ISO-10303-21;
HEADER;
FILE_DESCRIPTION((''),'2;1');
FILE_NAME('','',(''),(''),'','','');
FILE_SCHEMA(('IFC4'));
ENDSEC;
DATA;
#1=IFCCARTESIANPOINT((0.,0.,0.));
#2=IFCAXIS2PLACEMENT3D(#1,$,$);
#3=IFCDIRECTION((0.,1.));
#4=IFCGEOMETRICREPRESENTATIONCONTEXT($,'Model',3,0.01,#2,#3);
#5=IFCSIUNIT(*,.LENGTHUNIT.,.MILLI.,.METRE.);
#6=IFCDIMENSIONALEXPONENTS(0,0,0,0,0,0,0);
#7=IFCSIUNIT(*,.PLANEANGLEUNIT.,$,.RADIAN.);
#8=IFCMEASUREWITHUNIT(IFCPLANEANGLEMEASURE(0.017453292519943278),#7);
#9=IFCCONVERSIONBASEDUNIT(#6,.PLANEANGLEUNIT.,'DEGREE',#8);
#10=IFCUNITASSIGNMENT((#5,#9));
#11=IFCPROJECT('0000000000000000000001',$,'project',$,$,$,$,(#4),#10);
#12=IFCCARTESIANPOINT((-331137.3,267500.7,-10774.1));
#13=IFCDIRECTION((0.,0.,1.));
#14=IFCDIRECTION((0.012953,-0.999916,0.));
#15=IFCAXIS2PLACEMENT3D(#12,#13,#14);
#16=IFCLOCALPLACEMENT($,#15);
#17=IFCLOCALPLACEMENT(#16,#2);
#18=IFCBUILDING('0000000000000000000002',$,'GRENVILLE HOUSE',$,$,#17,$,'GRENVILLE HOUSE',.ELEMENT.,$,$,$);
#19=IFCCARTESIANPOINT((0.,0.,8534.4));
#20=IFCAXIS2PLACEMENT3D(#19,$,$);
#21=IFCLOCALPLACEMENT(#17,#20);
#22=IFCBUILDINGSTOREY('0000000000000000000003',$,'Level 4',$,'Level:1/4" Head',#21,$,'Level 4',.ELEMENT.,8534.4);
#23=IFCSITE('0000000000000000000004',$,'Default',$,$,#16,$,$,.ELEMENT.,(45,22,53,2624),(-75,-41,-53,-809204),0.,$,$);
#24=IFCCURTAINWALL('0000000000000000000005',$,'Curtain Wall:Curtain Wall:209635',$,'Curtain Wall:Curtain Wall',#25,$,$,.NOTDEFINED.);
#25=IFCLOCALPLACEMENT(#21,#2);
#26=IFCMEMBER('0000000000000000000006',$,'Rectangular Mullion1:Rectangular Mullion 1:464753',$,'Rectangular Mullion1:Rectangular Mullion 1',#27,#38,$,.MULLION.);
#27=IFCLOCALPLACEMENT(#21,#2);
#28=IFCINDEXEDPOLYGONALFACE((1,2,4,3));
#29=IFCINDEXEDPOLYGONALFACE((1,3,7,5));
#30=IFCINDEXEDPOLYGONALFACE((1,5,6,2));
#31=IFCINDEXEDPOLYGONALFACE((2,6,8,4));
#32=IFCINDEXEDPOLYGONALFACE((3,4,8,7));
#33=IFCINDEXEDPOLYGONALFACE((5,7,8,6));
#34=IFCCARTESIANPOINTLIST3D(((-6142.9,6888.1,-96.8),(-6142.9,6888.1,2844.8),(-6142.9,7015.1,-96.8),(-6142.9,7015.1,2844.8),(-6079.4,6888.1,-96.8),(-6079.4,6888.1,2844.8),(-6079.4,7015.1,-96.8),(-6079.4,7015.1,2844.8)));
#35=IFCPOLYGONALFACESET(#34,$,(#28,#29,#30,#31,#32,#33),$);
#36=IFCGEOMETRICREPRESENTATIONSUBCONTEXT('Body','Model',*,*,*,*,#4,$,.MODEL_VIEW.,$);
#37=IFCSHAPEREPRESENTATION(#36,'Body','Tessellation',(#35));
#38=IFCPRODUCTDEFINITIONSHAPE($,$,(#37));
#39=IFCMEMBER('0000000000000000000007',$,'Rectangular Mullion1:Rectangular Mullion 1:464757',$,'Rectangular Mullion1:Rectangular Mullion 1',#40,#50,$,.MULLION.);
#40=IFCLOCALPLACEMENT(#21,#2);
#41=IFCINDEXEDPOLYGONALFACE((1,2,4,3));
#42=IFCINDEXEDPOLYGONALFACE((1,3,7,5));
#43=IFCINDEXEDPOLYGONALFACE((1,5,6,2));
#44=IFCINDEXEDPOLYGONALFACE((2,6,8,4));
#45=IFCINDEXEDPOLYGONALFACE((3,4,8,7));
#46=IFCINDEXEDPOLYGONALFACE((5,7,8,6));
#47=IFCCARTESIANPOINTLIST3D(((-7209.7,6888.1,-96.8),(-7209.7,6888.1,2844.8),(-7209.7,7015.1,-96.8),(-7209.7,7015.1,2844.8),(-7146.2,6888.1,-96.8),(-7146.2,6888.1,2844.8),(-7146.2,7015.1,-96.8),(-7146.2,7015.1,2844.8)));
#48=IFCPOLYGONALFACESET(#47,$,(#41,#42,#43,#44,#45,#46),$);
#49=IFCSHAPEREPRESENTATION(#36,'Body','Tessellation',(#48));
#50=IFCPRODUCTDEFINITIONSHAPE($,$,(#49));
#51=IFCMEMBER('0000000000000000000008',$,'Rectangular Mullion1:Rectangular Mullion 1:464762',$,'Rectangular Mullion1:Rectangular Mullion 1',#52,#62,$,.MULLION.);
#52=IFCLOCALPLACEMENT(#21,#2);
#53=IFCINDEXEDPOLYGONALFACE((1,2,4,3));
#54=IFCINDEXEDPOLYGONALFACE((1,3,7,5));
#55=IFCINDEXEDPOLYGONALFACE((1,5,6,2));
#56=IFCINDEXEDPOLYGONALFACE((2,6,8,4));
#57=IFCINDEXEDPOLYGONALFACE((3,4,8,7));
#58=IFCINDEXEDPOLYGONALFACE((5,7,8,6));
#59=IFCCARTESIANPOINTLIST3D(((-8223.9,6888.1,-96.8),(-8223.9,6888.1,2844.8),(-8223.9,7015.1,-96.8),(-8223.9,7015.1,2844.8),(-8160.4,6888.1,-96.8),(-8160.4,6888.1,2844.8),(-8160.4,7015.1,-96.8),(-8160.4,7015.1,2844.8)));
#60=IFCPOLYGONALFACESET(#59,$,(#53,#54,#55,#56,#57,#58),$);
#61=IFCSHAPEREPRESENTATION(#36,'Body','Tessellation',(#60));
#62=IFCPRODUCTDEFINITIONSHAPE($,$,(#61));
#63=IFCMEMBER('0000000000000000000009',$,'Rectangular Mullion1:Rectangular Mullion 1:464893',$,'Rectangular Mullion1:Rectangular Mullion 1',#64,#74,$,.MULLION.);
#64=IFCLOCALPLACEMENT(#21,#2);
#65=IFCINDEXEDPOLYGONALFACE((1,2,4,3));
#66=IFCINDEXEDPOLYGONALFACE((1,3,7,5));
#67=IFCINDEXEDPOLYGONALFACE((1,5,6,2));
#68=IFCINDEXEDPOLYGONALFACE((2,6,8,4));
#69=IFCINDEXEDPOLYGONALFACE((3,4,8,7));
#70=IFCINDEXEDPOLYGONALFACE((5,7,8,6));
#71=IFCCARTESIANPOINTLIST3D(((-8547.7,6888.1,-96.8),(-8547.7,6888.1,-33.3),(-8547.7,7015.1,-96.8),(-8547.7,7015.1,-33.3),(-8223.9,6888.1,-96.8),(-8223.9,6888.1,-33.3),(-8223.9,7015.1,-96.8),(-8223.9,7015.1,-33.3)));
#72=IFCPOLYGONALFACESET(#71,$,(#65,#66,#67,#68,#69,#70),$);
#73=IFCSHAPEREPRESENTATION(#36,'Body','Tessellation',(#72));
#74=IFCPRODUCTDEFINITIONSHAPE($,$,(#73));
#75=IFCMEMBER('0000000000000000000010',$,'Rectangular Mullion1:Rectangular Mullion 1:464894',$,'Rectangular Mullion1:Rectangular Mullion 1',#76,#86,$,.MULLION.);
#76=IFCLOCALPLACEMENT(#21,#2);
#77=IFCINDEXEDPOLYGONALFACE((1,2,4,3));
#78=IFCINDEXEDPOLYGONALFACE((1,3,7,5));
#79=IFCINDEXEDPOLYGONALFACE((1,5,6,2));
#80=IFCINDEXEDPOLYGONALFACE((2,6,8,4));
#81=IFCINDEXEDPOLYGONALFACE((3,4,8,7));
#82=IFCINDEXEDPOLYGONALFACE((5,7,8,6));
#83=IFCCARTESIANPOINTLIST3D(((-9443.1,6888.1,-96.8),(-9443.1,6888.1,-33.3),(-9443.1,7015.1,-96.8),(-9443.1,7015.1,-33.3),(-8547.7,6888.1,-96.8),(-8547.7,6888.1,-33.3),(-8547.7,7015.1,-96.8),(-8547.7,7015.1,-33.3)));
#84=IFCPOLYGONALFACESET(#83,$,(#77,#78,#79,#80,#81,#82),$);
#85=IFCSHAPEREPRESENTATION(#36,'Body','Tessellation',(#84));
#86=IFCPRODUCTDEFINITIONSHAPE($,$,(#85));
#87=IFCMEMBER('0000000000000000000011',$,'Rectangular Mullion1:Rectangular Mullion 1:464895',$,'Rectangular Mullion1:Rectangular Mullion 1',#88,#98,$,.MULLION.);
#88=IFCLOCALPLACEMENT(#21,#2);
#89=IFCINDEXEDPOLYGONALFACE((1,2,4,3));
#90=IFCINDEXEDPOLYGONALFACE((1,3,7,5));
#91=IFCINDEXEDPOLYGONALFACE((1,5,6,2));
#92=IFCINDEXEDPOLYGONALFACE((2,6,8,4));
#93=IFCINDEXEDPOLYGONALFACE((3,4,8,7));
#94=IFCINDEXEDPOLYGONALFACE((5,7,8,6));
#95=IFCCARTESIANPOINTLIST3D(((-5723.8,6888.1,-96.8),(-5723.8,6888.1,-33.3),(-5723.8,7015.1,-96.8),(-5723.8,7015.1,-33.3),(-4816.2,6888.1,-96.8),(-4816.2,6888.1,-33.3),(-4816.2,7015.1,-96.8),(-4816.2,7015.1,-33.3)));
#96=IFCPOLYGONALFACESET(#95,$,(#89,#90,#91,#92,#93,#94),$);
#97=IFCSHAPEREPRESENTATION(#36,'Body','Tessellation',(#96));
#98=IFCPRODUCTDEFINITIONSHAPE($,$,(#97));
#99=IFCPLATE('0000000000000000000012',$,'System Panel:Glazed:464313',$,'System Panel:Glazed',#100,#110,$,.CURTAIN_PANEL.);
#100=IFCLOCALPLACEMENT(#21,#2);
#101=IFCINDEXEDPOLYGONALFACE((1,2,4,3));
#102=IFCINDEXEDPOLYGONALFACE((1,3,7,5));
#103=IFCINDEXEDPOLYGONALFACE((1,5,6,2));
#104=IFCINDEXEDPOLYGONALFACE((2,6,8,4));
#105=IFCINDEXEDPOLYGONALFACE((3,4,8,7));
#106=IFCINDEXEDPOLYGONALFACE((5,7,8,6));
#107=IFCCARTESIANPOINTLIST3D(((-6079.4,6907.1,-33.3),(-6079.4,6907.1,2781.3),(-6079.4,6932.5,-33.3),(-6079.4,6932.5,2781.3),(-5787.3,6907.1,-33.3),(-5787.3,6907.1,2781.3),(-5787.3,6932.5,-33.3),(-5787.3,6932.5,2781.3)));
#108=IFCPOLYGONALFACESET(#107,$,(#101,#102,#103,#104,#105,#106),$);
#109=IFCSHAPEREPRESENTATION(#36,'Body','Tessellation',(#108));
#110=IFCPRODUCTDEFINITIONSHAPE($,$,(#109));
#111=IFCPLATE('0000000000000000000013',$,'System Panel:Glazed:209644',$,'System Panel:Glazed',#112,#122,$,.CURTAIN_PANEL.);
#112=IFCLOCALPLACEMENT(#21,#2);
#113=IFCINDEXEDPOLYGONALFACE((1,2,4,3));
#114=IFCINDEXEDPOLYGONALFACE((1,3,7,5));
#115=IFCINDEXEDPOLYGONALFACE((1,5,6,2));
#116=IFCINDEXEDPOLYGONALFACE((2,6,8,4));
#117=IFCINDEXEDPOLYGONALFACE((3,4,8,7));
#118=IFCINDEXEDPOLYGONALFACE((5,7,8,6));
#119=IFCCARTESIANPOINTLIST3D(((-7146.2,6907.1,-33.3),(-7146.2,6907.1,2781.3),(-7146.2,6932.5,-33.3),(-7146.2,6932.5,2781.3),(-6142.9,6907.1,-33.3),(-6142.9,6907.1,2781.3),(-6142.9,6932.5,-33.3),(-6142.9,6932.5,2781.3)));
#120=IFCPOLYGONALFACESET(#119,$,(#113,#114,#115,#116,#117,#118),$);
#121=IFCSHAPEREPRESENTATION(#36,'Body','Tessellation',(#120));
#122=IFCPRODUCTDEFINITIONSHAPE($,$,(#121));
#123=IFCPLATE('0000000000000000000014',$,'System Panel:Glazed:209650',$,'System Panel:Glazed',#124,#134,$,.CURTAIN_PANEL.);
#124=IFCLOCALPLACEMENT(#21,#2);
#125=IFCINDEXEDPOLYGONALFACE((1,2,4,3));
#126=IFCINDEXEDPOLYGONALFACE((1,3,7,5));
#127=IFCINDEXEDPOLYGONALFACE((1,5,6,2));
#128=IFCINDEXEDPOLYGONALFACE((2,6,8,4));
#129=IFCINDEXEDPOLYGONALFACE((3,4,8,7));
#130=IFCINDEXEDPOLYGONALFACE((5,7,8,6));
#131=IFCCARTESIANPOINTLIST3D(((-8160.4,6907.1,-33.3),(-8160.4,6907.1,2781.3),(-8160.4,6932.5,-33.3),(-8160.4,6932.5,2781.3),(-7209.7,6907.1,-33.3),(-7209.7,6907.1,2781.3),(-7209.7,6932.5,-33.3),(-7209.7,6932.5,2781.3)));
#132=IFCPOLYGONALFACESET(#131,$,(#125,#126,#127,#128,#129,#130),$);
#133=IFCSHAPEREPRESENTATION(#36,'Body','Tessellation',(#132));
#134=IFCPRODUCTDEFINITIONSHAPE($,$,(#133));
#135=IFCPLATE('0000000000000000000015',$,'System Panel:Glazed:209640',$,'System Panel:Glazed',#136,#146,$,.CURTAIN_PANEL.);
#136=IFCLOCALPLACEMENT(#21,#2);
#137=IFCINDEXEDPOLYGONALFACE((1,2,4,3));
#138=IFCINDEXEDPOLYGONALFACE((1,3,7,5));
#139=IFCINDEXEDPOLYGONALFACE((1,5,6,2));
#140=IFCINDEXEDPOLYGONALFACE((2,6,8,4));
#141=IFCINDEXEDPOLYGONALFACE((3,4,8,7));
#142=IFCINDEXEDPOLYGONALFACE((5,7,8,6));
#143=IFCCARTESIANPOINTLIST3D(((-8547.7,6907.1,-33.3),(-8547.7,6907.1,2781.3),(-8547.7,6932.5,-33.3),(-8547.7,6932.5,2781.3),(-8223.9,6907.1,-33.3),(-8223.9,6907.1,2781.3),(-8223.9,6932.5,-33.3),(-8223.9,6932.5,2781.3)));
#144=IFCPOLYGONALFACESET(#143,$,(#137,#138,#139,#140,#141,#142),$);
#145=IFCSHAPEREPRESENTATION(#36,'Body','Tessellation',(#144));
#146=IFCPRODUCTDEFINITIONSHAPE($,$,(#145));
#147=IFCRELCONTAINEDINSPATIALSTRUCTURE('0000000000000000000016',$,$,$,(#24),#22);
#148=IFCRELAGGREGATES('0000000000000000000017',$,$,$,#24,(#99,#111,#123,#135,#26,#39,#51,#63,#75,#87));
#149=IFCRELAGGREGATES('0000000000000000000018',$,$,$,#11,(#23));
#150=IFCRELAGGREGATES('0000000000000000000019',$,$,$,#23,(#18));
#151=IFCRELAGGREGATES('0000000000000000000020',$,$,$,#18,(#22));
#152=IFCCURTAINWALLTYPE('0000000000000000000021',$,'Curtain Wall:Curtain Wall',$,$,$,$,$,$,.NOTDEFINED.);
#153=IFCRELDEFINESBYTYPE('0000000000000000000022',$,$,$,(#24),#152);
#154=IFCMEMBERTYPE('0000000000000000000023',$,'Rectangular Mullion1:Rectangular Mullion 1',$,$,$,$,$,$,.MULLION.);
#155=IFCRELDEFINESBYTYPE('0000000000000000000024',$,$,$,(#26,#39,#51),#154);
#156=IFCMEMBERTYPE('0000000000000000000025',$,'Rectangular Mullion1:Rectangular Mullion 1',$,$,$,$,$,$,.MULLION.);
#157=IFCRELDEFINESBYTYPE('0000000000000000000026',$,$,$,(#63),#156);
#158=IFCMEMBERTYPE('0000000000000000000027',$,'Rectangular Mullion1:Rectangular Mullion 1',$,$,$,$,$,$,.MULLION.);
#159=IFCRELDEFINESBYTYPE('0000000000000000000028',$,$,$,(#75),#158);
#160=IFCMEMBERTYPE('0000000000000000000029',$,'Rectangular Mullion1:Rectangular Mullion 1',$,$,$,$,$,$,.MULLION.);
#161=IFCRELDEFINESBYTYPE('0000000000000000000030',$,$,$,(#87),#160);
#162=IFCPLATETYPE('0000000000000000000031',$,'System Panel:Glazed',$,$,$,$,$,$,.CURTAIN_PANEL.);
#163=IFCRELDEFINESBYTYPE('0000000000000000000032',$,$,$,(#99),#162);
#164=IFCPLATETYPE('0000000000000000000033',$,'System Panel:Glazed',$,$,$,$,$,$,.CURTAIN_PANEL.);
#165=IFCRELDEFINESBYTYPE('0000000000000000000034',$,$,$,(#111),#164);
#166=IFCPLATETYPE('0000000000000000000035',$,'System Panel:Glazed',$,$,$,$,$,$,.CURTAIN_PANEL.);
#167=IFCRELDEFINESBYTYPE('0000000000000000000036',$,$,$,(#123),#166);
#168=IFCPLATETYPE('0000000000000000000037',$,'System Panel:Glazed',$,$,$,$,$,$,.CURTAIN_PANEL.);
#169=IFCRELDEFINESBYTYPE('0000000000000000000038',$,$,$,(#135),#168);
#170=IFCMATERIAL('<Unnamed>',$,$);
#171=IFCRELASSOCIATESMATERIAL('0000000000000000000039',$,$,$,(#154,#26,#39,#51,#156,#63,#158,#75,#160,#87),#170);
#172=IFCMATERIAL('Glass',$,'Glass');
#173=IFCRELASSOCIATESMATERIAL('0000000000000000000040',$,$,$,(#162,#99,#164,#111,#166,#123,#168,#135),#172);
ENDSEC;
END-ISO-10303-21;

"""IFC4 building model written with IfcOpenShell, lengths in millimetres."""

from ifc_helpers import new_model, entity, si_unit, converted_unit, direction, frame, origin, place, context, subcontext, project, spatial, indexed_curve, outline, extrude, source, transform, mapped, material, type_object, type_shapes, element, aggregate, save


model = new_model("IFC4")

# Units and contexts
model_context = context("Model", 3, precision=0.01, world=origin(), true_north=direction((0.0, 1.0)))
body_context = subcontext(model_context, "Body", "Model", "MODEL_VIEW")
ifc_project = project(units=[si_unit("LENGTHUNIT", "METRE", prefix="MILLI"), converted_unit("PLANEANGLEUNIT", "DEGREE", entity("IfcPlaneAngleMeasure", 0.017453292519943278), si_unit("PLANEANGLEUNIT", "RADIAN"), dimensions=[0, 0, 0, 0, 0, 0, 0])], contexts=[model_context])

# Site, building, storey
site_placement = place(None, frame((-331137.3, 267500.7, -10774.1), z_axis=(0.0, 0.0, 1.0), x_axis=(0.012953, -0.999916, 0.0)))
site = spatial("IfcSite", under=ifc_project, at=site_placement, Name="Default", CompositionType="ELEMENT", RefLatitude=(45, 22, 53, 2624), RefLongitude=(-75, -41, -53, -809204), RefElevation=0.0)
building_placement = place(site_placement, origin())
building = spatial("IfcBuilding", under=site, at=building_placement, Name="GRENVILLE HOUSE", LongName="GRENVILLE HOUSE", CompositionType="ELEMENT")
storey_placement = place(building_placement, frame((0.0, 0.0, 8534.4)))
storey = spatial("IfcBuildingStorey", under=building, at=storey_placement, Name="Level 4", ObjectType="Level:1/4\" Head", LongName="Level 4", CompositionType="ELEMENT", Elevation=8534.4)

# Curtain wall, members, plates
curtain_wall_type = type_object("IfcCurtainWallType", Name="Curtain Wall:Curtain Wall", PredefinedType="NOTDEFINED")
curtain_wall_placement = place(storey_placement, frame((0.0, 0.0, -8534.4)))
curtain_wall = element("IfcCurtainWall", 1, at=curtain_wall_placement, inside=storey, type_object=curtain_wall_type, Name="Curtain Wall:Curtain Wall:209635", ObjectType="Curtain Wall:Curtain Wall", PredefinedType="NOTDEFINED")
ifc_material_1 = material(Name="<Unnamed>")
member_type_1 = type_object("IfcMemberType", Name="Rectangular Mullion1:Rectangular Mullion 1", PredefinedType="MULLION", material=ifc_material_1)
shared_shape_1 = source(origin(), body_context, "Body", "SweptSolid", [
    extrude(outline(indexed_curve([(-31.8, -63.5), (31.8, -63.5), (31.8, 63.5), (-31.8, 63.5), (-31.8, -63.5)], self_intersect=False)), frame((0.0, 0.0, -2941.6), z_axis=(0.0, 0.0, 1.0), x_axis=(-1.0, 0.0, 0.0)), (0.0, 0.0, 1.0), 2941.6),
])
type_shapes(member_type_1, [shared_shape_1])
member_1_placement = place(curtain_wall_placement, frame((-6111.1, 6951.6, 8437.6), z_axis=(0.0, 0.0, -1.0), x_axis=(-1.0, 0.0, 0.0)))
member_1 = element("IfcMember", 2, at=member_1_placement, type_object=member_type_1, material=ifc_material_1, Name="Rectangular Mullion1:Rectangular Mullion 1:464753", ObjectType="Rectangular Mullion1:Rectangular Mullion 1", PredefinedType="MULLION", context=body_context, shape_type="MappedRepresentation", body=[
    mapped(shared_shape_1, transform((0.0, 0.0, 0.0), scale=1.0)),
])
member_2_placement = place(curtain_wall_placement, frame((-7177.9, 6951.6, 8437.6), z_axis=(0.0, 0.0, -1.0), x_axis=(-1.0, 0.0, 0.0)))
member_2 = element("IfcMember", 3, at=member_2_placement, type_object=member_type_1, material=ifc_material_1, Name="Rectangular Mullion1:Rectangular Mullion 1:464757", ObjectType="Rectangular Mullion1:Rectangular Mullion 1", PredefinedType="MULLION", context=body_context, shape_type="MappedRepresentation", body=[
    mapped(shared_shape_1, transform((0.0, 0.0, 0.0), scale=1.0)),
])
member_3_placement = place(curtain_wall_placement, frame((-8192.1, 6951.6, 8437.6), z_axis=(0.0, 0.0, -1.0), x_axis=(-1.0, 0.0, 0.0)))
member_3 = element("IfcMember", 4, at=member_3_placement, type_object=member_type_1, material=ifc_material_1, Name="Rectangular Mullion1:Rectangular Mullion 1:464762", ObjectType="Rectangular Mullion1:Rectangular Mullion 1", PredefinedType="MULLION", context=body_context, shape_type="MappedRepresentation", body=[
    mapped(shared_shape_1, transform((0.0, 0.0, 0.0), scale=1.0)),
])
member_type_2 = type_object("IfcMemberType", Name="Rectangular Mullion1:Rectangular Mullion 1", PredefinedType="MULLION", material=ifc_material_1)
shared_shape_2 = source(origin(), body_context, "Body", "SweptSolid", [
    extrude(outline(indexed_curve([(-31.8, -63.5), (31.8, -63.5), (31.8, 63.5), (-31.8, 63.5), (-31.8, -63.5)], self_intersect=False)), frame((-31.8, 0.0, -323.8), z_axis=(0.0, 0.0, 1.0), x_axis=(-1.0, 0.0, 0.0)), (0.0, 0.0, 1.0), 323.9),
])
type_shapes(member_type_2, [shared_shape_2])
member_4_placement = place(curtain_wall_placement, frame((-8223.9, 6951.6, 8437.6), z_axis=(1.0, 0.0, 0.0), x_axis=(0.0, 0.0, -1.0)))
member_4 = element("IfcMember", 5, at=member_4_placement, type_object=member_type_2, material=ifc_material_1, Name="Rectangular Mullion1:Rectangular Mullion 1:464893", ObjectType="Rectangular Mullion1:Rectangular Mullion 1", PredefinedType="MULLION", context=body_context, shape_type="MappedRepresentation", body=[
    mapped(shared_shape_2, transform((0.0, 0.0, 0.0), scale=1.0)),
])
member_type_3 = type_object("IfcMemberType", Name="Rectangular Mullion1:Rectangular Mullion 1", PredefinedType="MULLION", material=ifc_material_1)
shared_shape_3 = source(origin(), body_context, "Body", "SweptSolid", [
    extrude(outline(indexed_curve([(-31.8, -63.5), (31.8, -63.5), (31.8, 63.5), (-31.8, 63.5), (-31.8, -63.5)], self_intersect=False)), frame((-31.8, 0.0, -895.3), z_axis=(0.0, 0.0, 1.0), x_axis=(-1.0, 0.0, 0.0)), (0.0, 0.0, 1.0), 895.3),
])
type_shapes(member_type_3, [shared_shape_3])
member_5_placement = place(curtain_wall_placement, frame((-8547.7, 6951.6, 8437.6), z_axis=(1.0, 0.0, 0.0), x_axis=(0.0, 0.0, -1.0)))
member_5 = element("IfcMember", 6, at=member_5_placement, type_object=member_type_3, material=ifc_material_1, Name="Rectangular Mullion1:Rectangular Mullion 1:464894", ObjectType="Rectangular Mullion1:Rectangular Mullion 1", PredefinedType="MULLION", context=body_context, shape_type="MappedRepresentation", body=[
    mapped(shared_shape_3, transform((0.0, 0.0, 0.0), scale=1.0)),
])
member_type_4 = type_object("IfcMemberType", Name="Rectangular Mullion1:Rectangular Mullion 1", PredefinedType="MULLION", material=ifc_material_1)
shared_shape_4 = source(origin(), body_context, "Body", "SweptSolid", [
    extrude(outline(indexed_curve([(-31.8, -63.5), (31.8, -63.5), (31.8, 63.5), (-31.8, 63.5), (-31.8, -63.5)], self_intersect=False)), frame((-31.8, 0.0, -907.6), z_axis=(0.0, 0.0, 1.0), x_axis=(-1.0, 0.0, 0.0)), (0.0, 0.0, 1.0), 907.6),
])
type_shapes(member_type_4, [shared_shape_4])
member_6_placement = place(curtain_wall_placement, frame((-4816.2, 6951.6, 8437.6), z_axis=(1.0, 0.0, 0.0), x_axis=(0.0, 0.0, -1.0)))
member_6 = element("IfcMember", 7, at=member_6_placement, type_object=member_type_4, material=ifc_material_1, Name="Rectangular Mullion1:Rectangular Mullion 1:464895", ObjectType="Rectangular Mullion1:Rectangular Mullion 1", PredefinedType="MULLION", context=body_context, shape_type="MappedRepresentation", body=[
    mapped(shared_shape_4, transform((0.0, 0.0, 0.0), scale=1.0)),
])
ifc_material_2 = material(Name="Glass", Category="Glass")
plate_type_1 = type_object("IfcPlateType", Name="System Panel:Glazed", PredefinedType="CURTAIN_PANEL", material=ifc_material_2)
shared_shape_5 = source(origin(), body_context, "Body", "SweptSolid", [
    extrude(outline(indexed_curve([(-12.7, -146.0), (12.7, -146.0), (12.7, 146.0), (-12.7, 146.0), (-12.7, -146.0)], self_intersect=False)), frame((146.0, 12.7, 0.0), z_axis=(0.0, 0.0, 1.0), x_axis=(0.0, 1.0, 0.0)), (0.0, 0.0, 1.0), 2814.6),
])
type_shapes(plate_type_1, [shared_shape_5])
plate_1_placement = place(curtain_wall_placement, frame((-5787.3, 6932.5, 8501.1), z_axis=(0.0, 0.0, 1.0), x_axis=(-1.0, 0.0, 0.0)))
plate_1 = element("IfcPlate", 8, at=plate_1_placement, type_object=plate_type_1, material=ifc_material_2, Name="System Panel:Glazed:464313", ObjectType="System Panel:Glazed", PredefinedType="CURTAIN_PANEL", context=body_context, shape_type="MappedRepresentation", body=[
    mapped(shared_shape_5, transform((0.0, 0.0, 0.0), scale=1.0)),
])
plate_type_2 = type_object("IfcPlateType", Name="System Panel:Glazed", PredefinedType="CURTAIN_PANEL", material=ifc_material_2)
shared_shape_6 = source(origin(), body_context, "Body", "SweptSolid", [
    extrude(outline(indexed_curve([(-12.7, -501.6), (12.7, -501.6), (12.7, 501.6), (-12.7, 501.6), (-12.7, -501.6)], self_intersect=False)), frame((501.6, 12.7, 0.0), z_axis=(0.0, 0.0, 1.0), x_axis=(0.0, 1.0, 0.0)), (0.0, 0.0, 1.0), 2814.6),
])
type_shapes(plate_type_2, [shared_shape_6])
plate_2_placement = place(curtain_wall_placement, frame((-6142.9, 6932.5, 8501.1), z_axis=(0.0, 0.0, 1.0), x_axis=(-1.0, 0.0, 0.0)))
plate_2 = element("IfcPlate", 9, at=plate_2_placement, type_object=plate_type_2, material=ifc_material_2, Name="System Panel:Glazed:209644", ObjectType="System Panel:Glazed", PredefinedType="CURTAIN_PANEL", context=body_context, shape_type="MappedRepresentation", body=[
    mapped(shared_shape_6, transform((0.0, 0.0, 0.0), scale=1.0)),
])
plate_type_3 = type_object("IfcPlateType", Name="System Panel:Glazed", PredefinedType="CURTAIN_PANEL", material=ifc_material_2)
shared_shape_7 = source(origin(), body_context, "Body", "SweptSolid", [
    extrude(outline(indexed_curve([(-12.7, -475.3), (12.7, -475.3), (12.7, 475.3), (-12.7, 475.3), (-12.7, -475.3)], self_intersect=False)), frame((475.3, 12.7, 0.0), z_axis=(0.0, 0.0, 1.0), x_axis=(0.0, 1.0, 0.0)), (0.0, 0.0, 1.0), 2814.6),
])
type_shapes(plate_type_3, [shared_shape_7])
plate_3_placement = place(curtain_wall_placement, frame((-7209.7, 6932.5, 8501.1), z_axis=(0.0, 0.0, 1.0), x_axis=(-1.0, 0.0, 0.0)))
plate_3 = element("IfcPlate", 10, at=plate_3_placement, type_object=plate_type_3, material=ifc_material_2, Name="System Panel:Glazed:209650", ObjectType="System Panel:Glazed", PredefinedType="CURTAIN_PANEL", context=body_context, shape_type="MappedRepresentation", body=[
    mapped(shared_shape_7, transform((0.0, 0.0, 0.0), scale=1.0)),
])
plate_type_4 = type_object("IfcPlateType", Name="System Panel:Glazed", PredefinedType="CURTAIN_PANEL", material=ifc_material_2)
shared_shape_8 = source(origin(), body_context, "Body", "SweptSolid", [
    extrude(outline(indexed_curve([(-12.7, -161.9), (12.7, -161.9), (12.7, 161.9), (-12.7, 161.9), (-12.7, -161.9)], self_intersect=False)), frame((161.9, 12.7, 0.0), z_axis=(0.0, 0.0, 1.0), x_axis=(0.0, 1.0, 0.0)), (0.0, 0.0, 1.0), 2814.6),
])
type_shapes(plate_type_4, [shared_shape_8])
plate_4_placement = place(curtain_wall_placement, frame((-8223.9, 6932.5, 8501.1), z_axis=(0.0, 0.0, 1.0), x_axis=(-1.0, 0.0, 0.0)))
plate_4 = element("IfcPlate", 11, at=plate_4_placement, type_object=plate_type_4, material=ifc_material_2, Name="System Panel:Glazed:209640", ObjectType="System Panel:Glazed", PredefinedType="CURTAIN_PANEL", context=body_context, shape_type="MappedRepresentation", body=[
    mapped(shared_shape_8, transform((0.0, 0.0, 0.0), scale=1.0)),
])
aggregate(curtain_wall, [plate_1, plate_2, plate_3, plate_4, member_1, member_2, member_3, member_4, member_5, member_6])

save(model, "model.ifc")
